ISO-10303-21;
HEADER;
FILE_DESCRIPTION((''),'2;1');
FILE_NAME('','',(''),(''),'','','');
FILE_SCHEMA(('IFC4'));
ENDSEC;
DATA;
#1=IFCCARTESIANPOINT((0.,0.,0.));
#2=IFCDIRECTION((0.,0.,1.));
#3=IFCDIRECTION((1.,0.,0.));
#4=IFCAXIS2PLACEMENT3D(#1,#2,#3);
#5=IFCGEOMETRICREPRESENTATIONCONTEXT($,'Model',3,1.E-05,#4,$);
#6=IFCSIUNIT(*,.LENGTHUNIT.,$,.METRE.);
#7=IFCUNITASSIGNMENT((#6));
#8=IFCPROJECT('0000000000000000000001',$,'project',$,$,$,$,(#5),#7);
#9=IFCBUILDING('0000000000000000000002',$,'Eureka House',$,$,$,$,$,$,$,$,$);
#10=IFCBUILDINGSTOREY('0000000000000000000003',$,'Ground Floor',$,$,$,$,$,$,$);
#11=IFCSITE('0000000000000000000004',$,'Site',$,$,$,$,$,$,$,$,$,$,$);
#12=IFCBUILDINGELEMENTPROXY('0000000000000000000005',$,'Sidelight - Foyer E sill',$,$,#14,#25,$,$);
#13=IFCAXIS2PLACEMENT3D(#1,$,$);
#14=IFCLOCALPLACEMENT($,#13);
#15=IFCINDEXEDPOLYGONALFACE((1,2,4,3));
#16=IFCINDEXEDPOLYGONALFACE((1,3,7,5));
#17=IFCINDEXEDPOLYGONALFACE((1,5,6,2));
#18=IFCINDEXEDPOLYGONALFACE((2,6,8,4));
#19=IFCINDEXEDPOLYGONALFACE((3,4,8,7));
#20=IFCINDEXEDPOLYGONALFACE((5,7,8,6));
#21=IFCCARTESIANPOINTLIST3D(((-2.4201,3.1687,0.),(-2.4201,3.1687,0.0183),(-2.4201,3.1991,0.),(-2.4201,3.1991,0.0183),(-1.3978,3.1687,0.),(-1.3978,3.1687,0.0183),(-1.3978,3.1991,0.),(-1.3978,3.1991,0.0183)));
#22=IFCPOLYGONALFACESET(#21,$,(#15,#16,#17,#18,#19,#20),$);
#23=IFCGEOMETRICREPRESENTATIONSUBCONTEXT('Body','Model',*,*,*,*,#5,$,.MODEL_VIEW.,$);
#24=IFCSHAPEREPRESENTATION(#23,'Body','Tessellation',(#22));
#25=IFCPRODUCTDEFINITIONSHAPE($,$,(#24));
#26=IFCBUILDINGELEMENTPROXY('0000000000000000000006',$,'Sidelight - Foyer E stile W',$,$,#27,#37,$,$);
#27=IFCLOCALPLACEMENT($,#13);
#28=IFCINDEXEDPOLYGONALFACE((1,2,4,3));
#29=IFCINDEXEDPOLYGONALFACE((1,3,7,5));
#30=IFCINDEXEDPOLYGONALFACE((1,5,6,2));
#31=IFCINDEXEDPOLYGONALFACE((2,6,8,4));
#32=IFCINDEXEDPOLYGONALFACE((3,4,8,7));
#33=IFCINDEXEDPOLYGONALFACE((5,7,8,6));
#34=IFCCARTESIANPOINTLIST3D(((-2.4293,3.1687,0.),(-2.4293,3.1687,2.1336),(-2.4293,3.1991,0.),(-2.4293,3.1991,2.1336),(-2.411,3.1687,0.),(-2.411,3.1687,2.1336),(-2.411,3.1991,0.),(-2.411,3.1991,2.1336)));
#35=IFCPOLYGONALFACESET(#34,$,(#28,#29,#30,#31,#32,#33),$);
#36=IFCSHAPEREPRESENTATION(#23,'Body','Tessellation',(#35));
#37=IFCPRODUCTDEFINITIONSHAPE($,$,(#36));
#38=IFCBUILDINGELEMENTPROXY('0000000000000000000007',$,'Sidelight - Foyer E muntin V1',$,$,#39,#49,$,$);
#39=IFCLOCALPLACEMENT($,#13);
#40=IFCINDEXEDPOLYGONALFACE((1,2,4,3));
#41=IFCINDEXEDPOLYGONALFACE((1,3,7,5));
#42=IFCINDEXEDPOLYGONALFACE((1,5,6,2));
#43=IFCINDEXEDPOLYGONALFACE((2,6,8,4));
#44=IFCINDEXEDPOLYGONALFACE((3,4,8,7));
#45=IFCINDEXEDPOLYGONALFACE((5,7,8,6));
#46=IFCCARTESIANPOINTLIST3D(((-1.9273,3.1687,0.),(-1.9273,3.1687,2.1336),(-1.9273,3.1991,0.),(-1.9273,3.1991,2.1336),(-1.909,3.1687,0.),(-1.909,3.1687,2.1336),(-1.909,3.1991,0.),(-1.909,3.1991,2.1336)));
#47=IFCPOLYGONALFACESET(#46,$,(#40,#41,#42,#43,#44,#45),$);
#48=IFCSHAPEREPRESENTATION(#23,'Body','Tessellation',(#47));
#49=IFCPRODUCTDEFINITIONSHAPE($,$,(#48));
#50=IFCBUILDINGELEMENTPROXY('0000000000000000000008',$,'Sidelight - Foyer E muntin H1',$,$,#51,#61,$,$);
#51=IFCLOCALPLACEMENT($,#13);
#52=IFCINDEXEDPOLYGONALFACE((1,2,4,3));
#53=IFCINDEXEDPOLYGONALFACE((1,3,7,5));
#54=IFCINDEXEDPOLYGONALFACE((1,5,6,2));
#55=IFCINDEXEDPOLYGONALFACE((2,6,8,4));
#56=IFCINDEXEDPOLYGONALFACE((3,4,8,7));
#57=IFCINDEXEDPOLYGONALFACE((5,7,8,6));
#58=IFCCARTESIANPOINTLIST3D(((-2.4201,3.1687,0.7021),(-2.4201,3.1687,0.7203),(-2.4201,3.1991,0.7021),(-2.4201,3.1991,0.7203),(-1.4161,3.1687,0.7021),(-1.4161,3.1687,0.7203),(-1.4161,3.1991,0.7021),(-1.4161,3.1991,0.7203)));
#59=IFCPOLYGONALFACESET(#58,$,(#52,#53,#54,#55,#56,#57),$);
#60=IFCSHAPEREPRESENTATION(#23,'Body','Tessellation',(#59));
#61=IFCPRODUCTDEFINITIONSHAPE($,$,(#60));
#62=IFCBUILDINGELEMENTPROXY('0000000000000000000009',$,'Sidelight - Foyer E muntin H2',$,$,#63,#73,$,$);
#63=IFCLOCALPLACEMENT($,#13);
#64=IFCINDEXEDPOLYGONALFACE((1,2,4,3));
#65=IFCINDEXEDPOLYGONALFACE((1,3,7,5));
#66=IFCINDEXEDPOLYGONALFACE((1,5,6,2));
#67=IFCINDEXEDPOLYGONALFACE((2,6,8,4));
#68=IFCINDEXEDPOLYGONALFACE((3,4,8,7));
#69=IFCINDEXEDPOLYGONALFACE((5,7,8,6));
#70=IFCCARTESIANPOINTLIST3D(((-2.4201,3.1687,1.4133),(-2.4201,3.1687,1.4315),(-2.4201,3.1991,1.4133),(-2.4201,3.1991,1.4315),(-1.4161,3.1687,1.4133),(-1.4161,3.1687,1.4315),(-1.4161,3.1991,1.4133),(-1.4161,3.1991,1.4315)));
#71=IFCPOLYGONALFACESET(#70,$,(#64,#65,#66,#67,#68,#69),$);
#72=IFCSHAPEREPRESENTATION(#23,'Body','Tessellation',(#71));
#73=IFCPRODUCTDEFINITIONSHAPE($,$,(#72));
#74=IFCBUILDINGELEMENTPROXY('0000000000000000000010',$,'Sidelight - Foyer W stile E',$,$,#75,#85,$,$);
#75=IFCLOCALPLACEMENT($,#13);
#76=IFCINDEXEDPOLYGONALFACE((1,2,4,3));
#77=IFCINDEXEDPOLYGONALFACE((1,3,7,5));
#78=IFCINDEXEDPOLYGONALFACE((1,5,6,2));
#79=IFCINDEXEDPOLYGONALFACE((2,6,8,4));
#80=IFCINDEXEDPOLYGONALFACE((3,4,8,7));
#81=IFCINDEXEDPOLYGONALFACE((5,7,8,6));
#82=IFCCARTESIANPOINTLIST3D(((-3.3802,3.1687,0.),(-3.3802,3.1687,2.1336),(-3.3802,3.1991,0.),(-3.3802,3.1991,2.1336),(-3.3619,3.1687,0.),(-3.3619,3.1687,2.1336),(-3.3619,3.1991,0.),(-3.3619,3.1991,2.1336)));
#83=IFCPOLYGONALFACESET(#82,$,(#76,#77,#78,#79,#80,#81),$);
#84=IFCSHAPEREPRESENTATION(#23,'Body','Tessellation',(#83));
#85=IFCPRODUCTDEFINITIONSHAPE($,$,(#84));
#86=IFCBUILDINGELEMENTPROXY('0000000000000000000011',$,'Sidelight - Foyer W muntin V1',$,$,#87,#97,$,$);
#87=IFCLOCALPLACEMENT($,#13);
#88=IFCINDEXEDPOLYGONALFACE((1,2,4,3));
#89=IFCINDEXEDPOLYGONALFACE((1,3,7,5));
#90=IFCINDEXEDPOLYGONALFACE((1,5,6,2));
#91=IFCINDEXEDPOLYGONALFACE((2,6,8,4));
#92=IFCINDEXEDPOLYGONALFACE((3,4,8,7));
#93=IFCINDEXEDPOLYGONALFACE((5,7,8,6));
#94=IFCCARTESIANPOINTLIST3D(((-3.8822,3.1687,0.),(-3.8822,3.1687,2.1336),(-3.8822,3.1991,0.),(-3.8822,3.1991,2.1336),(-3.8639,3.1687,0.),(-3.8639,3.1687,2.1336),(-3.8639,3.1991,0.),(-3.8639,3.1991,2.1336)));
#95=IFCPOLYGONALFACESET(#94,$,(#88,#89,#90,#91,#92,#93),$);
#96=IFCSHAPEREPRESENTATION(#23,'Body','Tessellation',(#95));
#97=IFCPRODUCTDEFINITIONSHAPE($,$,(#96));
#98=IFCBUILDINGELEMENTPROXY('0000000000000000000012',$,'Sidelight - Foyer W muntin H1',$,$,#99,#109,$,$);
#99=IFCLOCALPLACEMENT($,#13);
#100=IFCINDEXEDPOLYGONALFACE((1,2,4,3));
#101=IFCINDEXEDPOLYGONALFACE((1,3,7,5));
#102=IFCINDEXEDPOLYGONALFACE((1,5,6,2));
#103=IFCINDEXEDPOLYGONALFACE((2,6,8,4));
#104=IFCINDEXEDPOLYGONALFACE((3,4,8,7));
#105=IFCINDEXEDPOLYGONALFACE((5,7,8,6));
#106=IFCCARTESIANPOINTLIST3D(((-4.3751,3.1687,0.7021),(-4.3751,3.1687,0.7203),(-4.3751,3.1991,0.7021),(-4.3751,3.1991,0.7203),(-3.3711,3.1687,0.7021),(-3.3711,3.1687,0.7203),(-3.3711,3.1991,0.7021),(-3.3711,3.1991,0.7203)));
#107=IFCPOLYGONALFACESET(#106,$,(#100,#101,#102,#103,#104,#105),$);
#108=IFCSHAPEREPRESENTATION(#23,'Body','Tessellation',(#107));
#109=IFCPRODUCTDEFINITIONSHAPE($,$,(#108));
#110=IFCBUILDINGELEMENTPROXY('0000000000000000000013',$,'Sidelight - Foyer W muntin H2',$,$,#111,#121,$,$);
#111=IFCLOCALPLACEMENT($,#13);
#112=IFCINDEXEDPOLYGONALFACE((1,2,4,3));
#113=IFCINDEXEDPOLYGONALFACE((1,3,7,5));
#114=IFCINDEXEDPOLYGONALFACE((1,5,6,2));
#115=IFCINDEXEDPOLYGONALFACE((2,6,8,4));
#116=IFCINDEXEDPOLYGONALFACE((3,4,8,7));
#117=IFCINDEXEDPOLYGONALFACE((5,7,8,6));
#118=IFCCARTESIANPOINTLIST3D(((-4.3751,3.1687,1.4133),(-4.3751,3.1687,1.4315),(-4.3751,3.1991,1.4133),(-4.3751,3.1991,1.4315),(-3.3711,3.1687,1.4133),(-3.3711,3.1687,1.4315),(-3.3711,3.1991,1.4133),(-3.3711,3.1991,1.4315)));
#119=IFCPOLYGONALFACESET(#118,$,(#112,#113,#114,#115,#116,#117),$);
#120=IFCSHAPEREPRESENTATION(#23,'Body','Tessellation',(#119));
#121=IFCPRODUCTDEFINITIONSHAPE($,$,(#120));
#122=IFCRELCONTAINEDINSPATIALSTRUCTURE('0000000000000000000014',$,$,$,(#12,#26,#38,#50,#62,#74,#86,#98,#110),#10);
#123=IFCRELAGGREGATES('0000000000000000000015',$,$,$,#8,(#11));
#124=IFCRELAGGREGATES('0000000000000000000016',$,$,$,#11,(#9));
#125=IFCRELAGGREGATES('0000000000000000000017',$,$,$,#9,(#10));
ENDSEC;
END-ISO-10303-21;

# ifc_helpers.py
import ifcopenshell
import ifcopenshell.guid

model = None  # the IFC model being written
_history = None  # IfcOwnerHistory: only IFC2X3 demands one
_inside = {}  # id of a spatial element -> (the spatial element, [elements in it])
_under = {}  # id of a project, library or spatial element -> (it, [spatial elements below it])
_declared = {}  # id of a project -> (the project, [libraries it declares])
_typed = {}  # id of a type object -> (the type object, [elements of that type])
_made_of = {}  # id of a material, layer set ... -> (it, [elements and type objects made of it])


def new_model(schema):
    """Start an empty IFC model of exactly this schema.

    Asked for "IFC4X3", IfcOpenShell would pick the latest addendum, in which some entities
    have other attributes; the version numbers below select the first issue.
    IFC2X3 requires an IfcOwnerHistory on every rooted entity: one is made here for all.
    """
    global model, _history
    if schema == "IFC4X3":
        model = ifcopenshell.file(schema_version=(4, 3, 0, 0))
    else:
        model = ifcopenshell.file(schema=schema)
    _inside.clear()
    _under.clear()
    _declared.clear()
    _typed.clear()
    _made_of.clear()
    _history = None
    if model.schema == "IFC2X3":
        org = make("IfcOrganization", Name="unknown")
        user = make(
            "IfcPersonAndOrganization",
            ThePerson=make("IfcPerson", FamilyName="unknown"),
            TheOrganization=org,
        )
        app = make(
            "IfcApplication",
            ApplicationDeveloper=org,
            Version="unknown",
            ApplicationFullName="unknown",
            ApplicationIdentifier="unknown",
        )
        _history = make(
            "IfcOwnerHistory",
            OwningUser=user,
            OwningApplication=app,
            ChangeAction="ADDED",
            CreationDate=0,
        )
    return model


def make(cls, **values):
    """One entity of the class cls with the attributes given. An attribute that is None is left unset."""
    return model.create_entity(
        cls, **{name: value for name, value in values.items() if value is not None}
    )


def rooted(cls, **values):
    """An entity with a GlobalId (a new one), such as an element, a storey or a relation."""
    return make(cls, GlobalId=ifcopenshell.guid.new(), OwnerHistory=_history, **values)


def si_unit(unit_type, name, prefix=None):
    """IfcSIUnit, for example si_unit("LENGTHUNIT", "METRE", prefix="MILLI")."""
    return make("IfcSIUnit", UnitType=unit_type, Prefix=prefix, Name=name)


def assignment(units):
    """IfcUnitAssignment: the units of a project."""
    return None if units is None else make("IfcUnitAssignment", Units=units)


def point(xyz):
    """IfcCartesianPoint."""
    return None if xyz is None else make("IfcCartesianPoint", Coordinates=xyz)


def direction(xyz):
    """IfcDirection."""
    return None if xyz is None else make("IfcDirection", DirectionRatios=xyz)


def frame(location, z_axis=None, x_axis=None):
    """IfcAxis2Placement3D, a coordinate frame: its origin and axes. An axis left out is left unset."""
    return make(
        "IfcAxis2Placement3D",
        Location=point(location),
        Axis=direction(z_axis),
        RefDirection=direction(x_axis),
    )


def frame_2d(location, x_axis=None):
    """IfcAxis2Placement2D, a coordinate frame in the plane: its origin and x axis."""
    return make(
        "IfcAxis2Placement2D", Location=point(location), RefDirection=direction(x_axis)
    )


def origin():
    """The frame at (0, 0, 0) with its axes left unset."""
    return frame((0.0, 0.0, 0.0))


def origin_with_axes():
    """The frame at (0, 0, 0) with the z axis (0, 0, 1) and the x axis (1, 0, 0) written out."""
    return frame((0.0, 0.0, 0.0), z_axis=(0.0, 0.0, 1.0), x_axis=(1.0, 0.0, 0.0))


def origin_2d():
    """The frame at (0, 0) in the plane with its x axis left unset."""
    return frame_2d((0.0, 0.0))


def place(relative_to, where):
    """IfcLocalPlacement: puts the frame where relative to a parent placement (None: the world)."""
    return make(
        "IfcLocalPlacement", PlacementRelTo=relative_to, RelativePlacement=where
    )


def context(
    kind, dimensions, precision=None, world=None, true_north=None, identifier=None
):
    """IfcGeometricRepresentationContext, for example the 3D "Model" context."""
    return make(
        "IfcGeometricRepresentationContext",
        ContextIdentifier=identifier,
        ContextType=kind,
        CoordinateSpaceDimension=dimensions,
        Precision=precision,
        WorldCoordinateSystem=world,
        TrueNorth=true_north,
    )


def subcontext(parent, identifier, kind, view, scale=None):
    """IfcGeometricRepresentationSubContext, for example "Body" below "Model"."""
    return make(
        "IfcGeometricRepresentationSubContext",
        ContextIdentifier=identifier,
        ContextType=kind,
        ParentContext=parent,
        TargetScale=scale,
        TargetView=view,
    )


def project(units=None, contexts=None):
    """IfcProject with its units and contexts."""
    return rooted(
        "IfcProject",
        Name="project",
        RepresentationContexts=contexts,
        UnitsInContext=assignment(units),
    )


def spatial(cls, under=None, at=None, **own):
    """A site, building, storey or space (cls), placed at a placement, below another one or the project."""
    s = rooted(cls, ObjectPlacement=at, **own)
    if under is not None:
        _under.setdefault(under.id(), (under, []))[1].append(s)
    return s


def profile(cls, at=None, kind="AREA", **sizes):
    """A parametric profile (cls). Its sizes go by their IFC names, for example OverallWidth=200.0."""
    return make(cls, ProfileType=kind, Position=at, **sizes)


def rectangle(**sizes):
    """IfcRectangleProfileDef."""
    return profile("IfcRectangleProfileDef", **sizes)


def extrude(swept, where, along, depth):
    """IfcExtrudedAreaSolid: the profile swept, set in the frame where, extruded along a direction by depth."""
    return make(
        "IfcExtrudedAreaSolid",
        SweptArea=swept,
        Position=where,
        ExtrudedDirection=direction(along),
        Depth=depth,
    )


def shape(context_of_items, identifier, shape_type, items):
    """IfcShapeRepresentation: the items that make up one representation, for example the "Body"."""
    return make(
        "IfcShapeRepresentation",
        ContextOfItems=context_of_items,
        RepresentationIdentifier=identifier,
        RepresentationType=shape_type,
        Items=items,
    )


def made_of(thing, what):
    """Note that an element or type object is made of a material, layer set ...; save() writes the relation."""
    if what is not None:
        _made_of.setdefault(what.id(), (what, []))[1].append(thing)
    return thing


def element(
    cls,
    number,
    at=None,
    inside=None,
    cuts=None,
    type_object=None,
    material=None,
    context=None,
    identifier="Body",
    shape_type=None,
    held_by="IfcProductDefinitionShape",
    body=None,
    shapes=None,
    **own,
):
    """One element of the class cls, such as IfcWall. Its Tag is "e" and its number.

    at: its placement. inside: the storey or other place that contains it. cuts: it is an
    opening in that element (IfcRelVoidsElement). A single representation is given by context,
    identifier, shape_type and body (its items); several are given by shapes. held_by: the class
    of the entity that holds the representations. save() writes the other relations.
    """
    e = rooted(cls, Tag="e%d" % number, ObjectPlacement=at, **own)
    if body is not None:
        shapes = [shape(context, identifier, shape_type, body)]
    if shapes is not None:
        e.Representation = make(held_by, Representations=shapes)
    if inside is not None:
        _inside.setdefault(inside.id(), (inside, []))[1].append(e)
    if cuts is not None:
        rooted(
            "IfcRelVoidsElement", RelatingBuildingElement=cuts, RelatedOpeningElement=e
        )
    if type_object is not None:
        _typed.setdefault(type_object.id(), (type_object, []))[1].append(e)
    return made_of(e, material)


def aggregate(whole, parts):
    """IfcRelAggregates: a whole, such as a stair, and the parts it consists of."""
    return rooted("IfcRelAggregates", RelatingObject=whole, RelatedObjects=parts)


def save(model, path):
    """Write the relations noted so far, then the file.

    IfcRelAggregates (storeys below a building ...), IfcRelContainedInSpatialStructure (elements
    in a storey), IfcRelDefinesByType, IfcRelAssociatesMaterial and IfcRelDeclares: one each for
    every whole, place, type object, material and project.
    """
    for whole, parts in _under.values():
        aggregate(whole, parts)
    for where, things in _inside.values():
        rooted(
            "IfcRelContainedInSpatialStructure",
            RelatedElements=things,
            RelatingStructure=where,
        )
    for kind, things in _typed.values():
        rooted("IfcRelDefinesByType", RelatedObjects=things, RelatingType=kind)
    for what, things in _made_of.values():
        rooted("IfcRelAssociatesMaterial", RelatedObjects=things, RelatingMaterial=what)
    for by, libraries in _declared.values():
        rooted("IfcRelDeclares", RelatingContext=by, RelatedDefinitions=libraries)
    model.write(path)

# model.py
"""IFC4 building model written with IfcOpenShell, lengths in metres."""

from ifc_helpers import new_model, si_unit, frame, origin, origin_with_axes, origin_2d, place, context, subcontext, project, spatial, rectangle, extrude, element, save


model = new_model("IFC4")

# Units and contexts
model_context = context("Model", 3, precision=1e-05, world=origin_with_axes())
body_context = subcontext(model_context, "Body", "Model", "MODEL_VIEW")
ifc_project = project(units=[si_unit("LENGTHUNIT", "METRE")], contexts=[model_context])

# Site, building, storey
site = spatial("IfcSite", under=ifc_project, Name="Site")
building = spatial("IfcBuilding", under=site, Name="Eureka House")
storey = spatial("IfcBuildingStorey", under=building, Name="Ground Floor")

# Building element proxies
proxy_1_placement = place(None, frame((-1.909, 3.1839, 0.0), z_axis=(0.0, 0.0, 1.0), x_axis=(1.0, 0.0, 0.0)))
element("IfcBuildingElementProxy", 1, at=proxy_1_placement, inside=storey, Name="Sidelight - Foyer E sill", context=body_context, shape_type="SweptSolid", body=[
    extrude(rectangle(XDim=1.0223, YDim=0.0305, at=origin_2d()), origin(), (0.0, 0.0, 1.0), 0.0183),
])
for number, where, z_axis, x_axis, name in (
    (2, (-2.4201, 3.1839, 0.0), (0.0, 0.0, 1.0), (1.0, 0.0, 0.0), "Sidelight - Foyer E stile W"),
    (3, (-1.9181, 3.1839, 0.0), (0.0, 0.0, 1.0), (1.0, 0.0, 0.0), "Sidelight - Foyer E muntin V1"),
):
    element("IfcBuildingElementProxy", number, at=place(None, frame(where, z_axis=z_axis, x_axis=x_axis)), inside=storey, Name=name, context=body_context, shape_type="SweptSolid", body=[
        extrude(rectangle(XDim=0.0183, YDim=0.0305, at=origin_2d()), origin(), (0.0, 0.0, 1.0), 2.1336),
    ])
proxy_2_placement = place(None, frame((-1.9181, 3.1839, 0.7021), z_axis=(0.0, 0.0, 1.0), x_axis=(1.0, 0.0, 0.0)))
element("IfcBuildingElementProxy", 4, at=proxy_2_placement, inside=storey, Name="Sidelight - Foyer E muntin H1", context=body_context, shape_type="SweptSolid", body=[
    extrude(rectangle(XDim=1.004, YDim=0.0305, at=origin_2d()), origin(), (0.0, 0.0, 1.0), 0.0183),
])
proxy_3_placement = place(None, frame((-1.9181, 3.1839, 1.4133), z_axis=(0.0, 0.0, 1.0), x_axis=(1.0, 0.0, 0.0)))
element("IfcBuildingElementProxy", 5, at=proxy_3_placement, inside=storey, Name="Sidelight - Foyer E muntin H2", context=body_context, shape_type="SweptSolid", body=[
    extrude(rectangle(XDim=1.004, YDim=0.0305, at=origin_2d()), origin(), (0.0, 0.0, 1.0), 0.0183),
])
for number, where, z_axis, x_axis, name in (
    (6, (-3.3711, 3.1839, 0.0), (0.0, 0.0, 1.0), (1.0, 0.0, 0.0), "Sidelight - Foyer W stile E"),
    (7, (-3.8731, 3.1839, 0.0), (0.0, 0.0, 1.0), (1.0, 0.0, 0.0), "Sidelight - Foyer W muntin V1"),
):
    element("IfcBuildingElementProxy", number, at=place(None, frame(where, z_axis=z_axis, x_axis=x_axis)), inside=storey, Name=name, context=body_context, shape_type="SweptSolid", body=[
        extrude(rectangle(XDim=0.0183, YDim=0.0305, at=origin_2d()), origin(), (0.0, 0.0, 1.0), 2.1336),
    ])
proxy_4_placement = place(None, frame((-3.8731, 3.1839, 0.7021), z_axis=(0.0, 0.0, 1.0), x_axis=(1.0, 0.0, 0.0)))
element("IfcBuildingElementProxy", 8, at=proxy_4_placement, inside=storey, Name="Sidelight - Foyer W muntin H1", context=body_context, shape_type="SweptSolid", body=[
    extrude(rectangle(XDim=1.004, YDim=0.0305, at=origin_2d()), origin(), (0.0, 0.0, 1.0), 0.0183),
])
proxy_5_placement = place(None, frame((-3.8731, 3.1839, 1.4133), z_axis=(0.0, 0.0, 1.0), x_axis=(1.0, 0.0, 0.0)))
element("IfcBuildingElementProxy", 9, at=proxy_5_placement, inside=storey, Name="Sidelight - Foyer W muntin H2", context=body_context, shape_type="SweptSolid", body=[
    extrude(rectangle(XDim=1.004, YDim=0.0305, at=origin_2d()), origin(), (0.0, 0.0, 1.0), 0.0183),
])

save(model, "model.ifc")
